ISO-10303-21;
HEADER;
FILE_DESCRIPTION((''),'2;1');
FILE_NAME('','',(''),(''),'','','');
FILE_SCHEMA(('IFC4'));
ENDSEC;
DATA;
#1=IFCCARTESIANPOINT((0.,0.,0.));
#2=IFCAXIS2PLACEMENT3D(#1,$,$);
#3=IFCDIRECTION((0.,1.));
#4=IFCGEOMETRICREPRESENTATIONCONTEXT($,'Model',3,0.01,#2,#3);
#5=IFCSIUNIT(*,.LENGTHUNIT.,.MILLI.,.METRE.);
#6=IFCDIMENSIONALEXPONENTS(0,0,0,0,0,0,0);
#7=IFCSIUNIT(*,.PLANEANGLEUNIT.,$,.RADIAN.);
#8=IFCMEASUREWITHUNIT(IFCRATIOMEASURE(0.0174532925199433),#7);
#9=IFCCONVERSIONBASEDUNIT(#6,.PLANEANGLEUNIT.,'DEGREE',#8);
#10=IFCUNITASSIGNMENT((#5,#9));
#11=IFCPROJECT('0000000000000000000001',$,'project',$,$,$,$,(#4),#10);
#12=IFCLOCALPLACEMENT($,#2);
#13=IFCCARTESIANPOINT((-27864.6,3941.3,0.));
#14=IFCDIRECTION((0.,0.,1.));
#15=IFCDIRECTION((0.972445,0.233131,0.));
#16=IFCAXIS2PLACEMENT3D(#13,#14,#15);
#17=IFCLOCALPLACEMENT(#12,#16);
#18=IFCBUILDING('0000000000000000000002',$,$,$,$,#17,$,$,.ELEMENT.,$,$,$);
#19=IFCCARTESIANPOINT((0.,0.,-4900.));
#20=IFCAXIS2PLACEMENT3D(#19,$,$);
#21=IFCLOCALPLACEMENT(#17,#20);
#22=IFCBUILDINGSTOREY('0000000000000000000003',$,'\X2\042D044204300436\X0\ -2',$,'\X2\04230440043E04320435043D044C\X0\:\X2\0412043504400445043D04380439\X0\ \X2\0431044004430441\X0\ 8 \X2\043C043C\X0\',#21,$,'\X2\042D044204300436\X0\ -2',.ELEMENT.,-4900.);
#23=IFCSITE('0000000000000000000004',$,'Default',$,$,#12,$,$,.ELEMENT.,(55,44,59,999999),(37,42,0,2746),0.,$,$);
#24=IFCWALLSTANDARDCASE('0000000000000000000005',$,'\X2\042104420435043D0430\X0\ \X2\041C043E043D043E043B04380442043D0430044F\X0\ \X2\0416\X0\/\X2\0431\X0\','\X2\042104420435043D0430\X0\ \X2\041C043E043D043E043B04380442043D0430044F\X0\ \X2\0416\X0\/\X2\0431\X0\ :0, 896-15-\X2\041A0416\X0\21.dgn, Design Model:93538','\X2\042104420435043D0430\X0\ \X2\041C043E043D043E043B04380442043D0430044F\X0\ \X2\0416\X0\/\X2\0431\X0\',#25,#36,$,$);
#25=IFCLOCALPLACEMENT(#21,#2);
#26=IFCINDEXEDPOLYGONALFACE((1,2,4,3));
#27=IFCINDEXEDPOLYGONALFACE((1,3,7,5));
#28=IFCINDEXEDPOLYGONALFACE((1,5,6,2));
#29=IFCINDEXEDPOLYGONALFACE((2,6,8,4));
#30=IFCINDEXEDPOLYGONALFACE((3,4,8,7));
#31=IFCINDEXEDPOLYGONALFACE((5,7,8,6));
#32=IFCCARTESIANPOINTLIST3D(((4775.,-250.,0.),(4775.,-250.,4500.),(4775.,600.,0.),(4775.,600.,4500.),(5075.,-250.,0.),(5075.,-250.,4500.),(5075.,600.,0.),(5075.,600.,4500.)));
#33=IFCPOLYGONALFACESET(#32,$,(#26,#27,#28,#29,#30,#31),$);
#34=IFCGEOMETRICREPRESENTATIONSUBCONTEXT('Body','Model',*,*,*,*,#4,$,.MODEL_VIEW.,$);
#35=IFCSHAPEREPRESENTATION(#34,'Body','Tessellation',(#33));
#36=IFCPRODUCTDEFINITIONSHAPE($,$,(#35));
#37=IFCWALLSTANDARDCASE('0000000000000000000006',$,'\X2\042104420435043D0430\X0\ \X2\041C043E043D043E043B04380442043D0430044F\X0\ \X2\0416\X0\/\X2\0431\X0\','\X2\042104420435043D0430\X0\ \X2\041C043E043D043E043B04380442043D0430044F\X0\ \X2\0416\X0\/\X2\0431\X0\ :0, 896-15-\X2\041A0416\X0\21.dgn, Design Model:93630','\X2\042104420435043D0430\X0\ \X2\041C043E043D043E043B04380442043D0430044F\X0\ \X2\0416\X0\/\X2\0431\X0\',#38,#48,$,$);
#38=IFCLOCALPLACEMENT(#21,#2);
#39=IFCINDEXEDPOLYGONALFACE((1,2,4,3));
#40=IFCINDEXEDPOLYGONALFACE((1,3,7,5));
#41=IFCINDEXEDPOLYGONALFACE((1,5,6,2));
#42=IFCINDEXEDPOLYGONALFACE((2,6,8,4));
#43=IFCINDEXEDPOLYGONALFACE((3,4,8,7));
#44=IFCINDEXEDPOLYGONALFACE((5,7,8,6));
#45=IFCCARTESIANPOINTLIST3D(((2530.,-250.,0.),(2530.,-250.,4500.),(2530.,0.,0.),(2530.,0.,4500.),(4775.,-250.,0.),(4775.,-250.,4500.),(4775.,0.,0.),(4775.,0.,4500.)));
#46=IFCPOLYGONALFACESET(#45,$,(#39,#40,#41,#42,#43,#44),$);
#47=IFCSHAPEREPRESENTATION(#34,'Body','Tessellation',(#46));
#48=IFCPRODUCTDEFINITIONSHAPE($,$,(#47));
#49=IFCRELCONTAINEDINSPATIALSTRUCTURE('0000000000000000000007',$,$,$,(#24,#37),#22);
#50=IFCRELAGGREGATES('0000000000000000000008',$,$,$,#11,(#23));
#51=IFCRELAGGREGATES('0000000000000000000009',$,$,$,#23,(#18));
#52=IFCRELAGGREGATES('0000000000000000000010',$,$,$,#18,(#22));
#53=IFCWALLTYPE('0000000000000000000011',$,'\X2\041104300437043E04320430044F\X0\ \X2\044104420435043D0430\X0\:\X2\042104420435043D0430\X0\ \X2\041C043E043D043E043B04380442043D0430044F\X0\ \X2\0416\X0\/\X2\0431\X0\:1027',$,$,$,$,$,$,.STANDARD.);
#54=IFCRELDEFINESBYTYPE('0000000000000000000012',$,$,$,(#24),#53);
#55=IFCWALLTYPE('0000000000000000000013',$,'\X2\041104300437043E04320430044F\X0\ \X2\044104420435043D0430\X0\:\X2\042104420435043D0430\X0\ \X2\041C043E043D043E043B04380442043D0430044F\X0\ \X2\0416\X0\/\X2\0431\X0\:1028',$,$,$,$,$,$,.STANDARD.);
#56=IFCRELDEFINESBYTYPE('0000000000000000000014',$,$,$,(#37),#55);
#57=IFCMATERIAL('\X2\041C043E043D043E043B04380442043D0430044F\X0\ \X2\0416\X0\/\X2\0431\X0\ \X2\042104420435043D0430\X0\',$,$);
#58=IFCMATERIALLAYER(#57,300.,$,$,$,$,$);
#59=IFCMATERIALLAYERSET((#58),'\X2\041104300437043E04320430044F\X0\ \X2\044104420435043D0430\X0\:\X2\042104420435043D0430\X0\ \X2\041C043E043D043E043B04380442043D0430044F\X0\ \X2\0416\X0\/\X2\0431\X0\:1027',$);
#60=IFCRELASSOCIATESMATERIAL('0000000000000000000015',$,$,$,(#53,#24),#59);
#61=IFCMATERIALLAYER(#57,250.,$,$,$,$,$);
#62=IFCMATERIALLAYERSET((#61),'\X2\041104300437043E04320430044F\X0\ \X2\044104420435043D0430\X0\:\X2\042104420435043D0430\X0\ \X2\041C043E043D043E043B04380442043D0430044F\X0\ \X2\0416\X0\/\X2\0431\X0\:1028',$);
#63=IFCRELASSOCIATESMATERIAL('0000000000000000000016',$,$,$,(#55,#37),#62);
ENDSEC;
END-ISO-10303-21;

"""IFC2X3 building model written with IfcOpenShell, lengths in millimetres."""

from ifc_helpers import new_model, entity, si_unit, converted_unit, direction, frame, frame_2d, origin, place, context, subcontext, project, spatial, rectangle, extrude, material, layer, layer_set, layer_usage, type_object, element, save


model = new_model("IFC2X3")

# Units and contexts
model_context = context("Model", 3, precision=0.01, world=origin(), true_north=direction((0.0, 1.0)))
body_context = subcontext(model_context, "Body", "Model", "MODEL_VIEW")
ifc_project = project(units=[si_unit("LENGTHUNIT", "METRE", prefix="MILLI"), converted_unit("PLANEANGLEUNIT", "DEGREE", entity("IfcRatioMeasure", 0.0174532925199433), si_unit("PLANEANGLEUNIT", "RADIAN"), dimensions=[0, 0, 0, 0, 0, 0, 0])], contexts=[model_context])

# Site, building, storey
site_placement = place(None, origin())
site = spatial("IfcSite", under=ifc_project, at=site_placement, Name="Default", CompositionType="ELEMENT", RefLatitude=(55, 44, 59, 999999), RefLongitude=(37, 42, 0, 2746), RefElevation=0.0)
building_placement = place(site_placement, frame((-27864.6, 3941.3, 0.0), z_axis=(0.0, 0.0, 1.0), x_axis=(0.972445, 0.233131, 0.0)))
building = spatial("IfcBuilding", under=site, at=building_placement, CompositionType="ELEMENT")
storey_placement = place(building_placement, frame((0.0, 0.0, -4900.0)))
storey = spatial("IfcBuildingStorey", under=building, at=storey_placement, Name="Этаж -2", ObjectType="Уровень:Верхний брус 8 мм", LongName="Этаж -2", CompositionType="ELEMENT", Elevation=-4900.0)

# Shared definitions
ifc_material = material(Name="Монолитная Ж/б Стена")

# Walls
ifc_layer_1 = layer(ifc_material, 300.0)
ifc_layer_set_1 = layer_set([ifc_layer_1], Name="Базовая стена:Стена Монолитная Ж/б:1027")
wall_type_1 = type_object("IfcWallType", Name="Базовая стена:Стена Монолитная Ж/б:1027", PredefinedType="STANDARD", material=ifc_layer_set_1)
ifc_layer_usage_1 = layer_usage(ifc_layer_set_1, "AXIS2", "NEGATIVE", 150.0)
wall_1_placement = place(storey_placement, frame((4925.0, -250.0, 0.0), z_axis=(0.0, 0.0, 1.0), x_axis=(0.0, 1.0, 0.0)))
element("IfcWallStandardCase", 1, at=wall_1_placement, inside=storey, type_object=wall_type_1, material=ifc_layer_usage_1, Name="Стена Монолитная Ж/б", Description="Стена Монолитная Ж/б :0, 896-15-КЖ21.dgn, Design Model:93538", ObjectType="Стена Монолитная Ж/б", context=body_context, shape_type="SweptSolid", body=[
    extrude(rectangle(XDim=850.0, YDim=300.0, at=frame_2d((425.0, 0.0), x_axis=(-1.0, 0.0))), origin(), (0.0, 0.0, 1.0), 4500.0),
])
ifc_layer_2 = layer(ifc_material, 250.0)
ifc_layer_set_2 = layer_set([ifc_layer_2], Name="Базовая стена:Стена Монолитная Ж/б:1028")
ifc_layer_usage_2 = layer_usage(ifc_layer_set_2, "AXIS2", "NEGATIVE", 125.0)
wall_type_2 = type_object("IfcWallType", Name="Базовая стена:Стена Монолитная Ж/б:1028", PredefinedType="STANDARD", material=ifc_layer_set_2)
wall_2_placement = place(storey_placement, frame((4775.0, -125.0, 0.0), z_axis=(0.0, 0.0, 1.0), x_axis=(-1.0, 0.0, 0.0)))
element("IfcWallStandardCase", 2, at=wall_2_placement, inside=storey, type_object=wall_type_2, material=ifc_layer_usage_2, Name="Стена Монолитная Ж/б", Description="Стена Монолитная Ж/б :0, 896-15-КЖ21.dgn, Design Model:93630", ObjectType="Стена Монолитная Ж/б", context=body_context, shape_type="SweptSolid", body=[
    extrude(rectangle(XDim=2245.0, YDim=250.0, at=frame_2d((1122.5, 0.0), x_axis=(-1.0, 0.0))), origin(), (0.0, 0.0, 1.0), 4500.0),
])

save(model, "model.ifc")
